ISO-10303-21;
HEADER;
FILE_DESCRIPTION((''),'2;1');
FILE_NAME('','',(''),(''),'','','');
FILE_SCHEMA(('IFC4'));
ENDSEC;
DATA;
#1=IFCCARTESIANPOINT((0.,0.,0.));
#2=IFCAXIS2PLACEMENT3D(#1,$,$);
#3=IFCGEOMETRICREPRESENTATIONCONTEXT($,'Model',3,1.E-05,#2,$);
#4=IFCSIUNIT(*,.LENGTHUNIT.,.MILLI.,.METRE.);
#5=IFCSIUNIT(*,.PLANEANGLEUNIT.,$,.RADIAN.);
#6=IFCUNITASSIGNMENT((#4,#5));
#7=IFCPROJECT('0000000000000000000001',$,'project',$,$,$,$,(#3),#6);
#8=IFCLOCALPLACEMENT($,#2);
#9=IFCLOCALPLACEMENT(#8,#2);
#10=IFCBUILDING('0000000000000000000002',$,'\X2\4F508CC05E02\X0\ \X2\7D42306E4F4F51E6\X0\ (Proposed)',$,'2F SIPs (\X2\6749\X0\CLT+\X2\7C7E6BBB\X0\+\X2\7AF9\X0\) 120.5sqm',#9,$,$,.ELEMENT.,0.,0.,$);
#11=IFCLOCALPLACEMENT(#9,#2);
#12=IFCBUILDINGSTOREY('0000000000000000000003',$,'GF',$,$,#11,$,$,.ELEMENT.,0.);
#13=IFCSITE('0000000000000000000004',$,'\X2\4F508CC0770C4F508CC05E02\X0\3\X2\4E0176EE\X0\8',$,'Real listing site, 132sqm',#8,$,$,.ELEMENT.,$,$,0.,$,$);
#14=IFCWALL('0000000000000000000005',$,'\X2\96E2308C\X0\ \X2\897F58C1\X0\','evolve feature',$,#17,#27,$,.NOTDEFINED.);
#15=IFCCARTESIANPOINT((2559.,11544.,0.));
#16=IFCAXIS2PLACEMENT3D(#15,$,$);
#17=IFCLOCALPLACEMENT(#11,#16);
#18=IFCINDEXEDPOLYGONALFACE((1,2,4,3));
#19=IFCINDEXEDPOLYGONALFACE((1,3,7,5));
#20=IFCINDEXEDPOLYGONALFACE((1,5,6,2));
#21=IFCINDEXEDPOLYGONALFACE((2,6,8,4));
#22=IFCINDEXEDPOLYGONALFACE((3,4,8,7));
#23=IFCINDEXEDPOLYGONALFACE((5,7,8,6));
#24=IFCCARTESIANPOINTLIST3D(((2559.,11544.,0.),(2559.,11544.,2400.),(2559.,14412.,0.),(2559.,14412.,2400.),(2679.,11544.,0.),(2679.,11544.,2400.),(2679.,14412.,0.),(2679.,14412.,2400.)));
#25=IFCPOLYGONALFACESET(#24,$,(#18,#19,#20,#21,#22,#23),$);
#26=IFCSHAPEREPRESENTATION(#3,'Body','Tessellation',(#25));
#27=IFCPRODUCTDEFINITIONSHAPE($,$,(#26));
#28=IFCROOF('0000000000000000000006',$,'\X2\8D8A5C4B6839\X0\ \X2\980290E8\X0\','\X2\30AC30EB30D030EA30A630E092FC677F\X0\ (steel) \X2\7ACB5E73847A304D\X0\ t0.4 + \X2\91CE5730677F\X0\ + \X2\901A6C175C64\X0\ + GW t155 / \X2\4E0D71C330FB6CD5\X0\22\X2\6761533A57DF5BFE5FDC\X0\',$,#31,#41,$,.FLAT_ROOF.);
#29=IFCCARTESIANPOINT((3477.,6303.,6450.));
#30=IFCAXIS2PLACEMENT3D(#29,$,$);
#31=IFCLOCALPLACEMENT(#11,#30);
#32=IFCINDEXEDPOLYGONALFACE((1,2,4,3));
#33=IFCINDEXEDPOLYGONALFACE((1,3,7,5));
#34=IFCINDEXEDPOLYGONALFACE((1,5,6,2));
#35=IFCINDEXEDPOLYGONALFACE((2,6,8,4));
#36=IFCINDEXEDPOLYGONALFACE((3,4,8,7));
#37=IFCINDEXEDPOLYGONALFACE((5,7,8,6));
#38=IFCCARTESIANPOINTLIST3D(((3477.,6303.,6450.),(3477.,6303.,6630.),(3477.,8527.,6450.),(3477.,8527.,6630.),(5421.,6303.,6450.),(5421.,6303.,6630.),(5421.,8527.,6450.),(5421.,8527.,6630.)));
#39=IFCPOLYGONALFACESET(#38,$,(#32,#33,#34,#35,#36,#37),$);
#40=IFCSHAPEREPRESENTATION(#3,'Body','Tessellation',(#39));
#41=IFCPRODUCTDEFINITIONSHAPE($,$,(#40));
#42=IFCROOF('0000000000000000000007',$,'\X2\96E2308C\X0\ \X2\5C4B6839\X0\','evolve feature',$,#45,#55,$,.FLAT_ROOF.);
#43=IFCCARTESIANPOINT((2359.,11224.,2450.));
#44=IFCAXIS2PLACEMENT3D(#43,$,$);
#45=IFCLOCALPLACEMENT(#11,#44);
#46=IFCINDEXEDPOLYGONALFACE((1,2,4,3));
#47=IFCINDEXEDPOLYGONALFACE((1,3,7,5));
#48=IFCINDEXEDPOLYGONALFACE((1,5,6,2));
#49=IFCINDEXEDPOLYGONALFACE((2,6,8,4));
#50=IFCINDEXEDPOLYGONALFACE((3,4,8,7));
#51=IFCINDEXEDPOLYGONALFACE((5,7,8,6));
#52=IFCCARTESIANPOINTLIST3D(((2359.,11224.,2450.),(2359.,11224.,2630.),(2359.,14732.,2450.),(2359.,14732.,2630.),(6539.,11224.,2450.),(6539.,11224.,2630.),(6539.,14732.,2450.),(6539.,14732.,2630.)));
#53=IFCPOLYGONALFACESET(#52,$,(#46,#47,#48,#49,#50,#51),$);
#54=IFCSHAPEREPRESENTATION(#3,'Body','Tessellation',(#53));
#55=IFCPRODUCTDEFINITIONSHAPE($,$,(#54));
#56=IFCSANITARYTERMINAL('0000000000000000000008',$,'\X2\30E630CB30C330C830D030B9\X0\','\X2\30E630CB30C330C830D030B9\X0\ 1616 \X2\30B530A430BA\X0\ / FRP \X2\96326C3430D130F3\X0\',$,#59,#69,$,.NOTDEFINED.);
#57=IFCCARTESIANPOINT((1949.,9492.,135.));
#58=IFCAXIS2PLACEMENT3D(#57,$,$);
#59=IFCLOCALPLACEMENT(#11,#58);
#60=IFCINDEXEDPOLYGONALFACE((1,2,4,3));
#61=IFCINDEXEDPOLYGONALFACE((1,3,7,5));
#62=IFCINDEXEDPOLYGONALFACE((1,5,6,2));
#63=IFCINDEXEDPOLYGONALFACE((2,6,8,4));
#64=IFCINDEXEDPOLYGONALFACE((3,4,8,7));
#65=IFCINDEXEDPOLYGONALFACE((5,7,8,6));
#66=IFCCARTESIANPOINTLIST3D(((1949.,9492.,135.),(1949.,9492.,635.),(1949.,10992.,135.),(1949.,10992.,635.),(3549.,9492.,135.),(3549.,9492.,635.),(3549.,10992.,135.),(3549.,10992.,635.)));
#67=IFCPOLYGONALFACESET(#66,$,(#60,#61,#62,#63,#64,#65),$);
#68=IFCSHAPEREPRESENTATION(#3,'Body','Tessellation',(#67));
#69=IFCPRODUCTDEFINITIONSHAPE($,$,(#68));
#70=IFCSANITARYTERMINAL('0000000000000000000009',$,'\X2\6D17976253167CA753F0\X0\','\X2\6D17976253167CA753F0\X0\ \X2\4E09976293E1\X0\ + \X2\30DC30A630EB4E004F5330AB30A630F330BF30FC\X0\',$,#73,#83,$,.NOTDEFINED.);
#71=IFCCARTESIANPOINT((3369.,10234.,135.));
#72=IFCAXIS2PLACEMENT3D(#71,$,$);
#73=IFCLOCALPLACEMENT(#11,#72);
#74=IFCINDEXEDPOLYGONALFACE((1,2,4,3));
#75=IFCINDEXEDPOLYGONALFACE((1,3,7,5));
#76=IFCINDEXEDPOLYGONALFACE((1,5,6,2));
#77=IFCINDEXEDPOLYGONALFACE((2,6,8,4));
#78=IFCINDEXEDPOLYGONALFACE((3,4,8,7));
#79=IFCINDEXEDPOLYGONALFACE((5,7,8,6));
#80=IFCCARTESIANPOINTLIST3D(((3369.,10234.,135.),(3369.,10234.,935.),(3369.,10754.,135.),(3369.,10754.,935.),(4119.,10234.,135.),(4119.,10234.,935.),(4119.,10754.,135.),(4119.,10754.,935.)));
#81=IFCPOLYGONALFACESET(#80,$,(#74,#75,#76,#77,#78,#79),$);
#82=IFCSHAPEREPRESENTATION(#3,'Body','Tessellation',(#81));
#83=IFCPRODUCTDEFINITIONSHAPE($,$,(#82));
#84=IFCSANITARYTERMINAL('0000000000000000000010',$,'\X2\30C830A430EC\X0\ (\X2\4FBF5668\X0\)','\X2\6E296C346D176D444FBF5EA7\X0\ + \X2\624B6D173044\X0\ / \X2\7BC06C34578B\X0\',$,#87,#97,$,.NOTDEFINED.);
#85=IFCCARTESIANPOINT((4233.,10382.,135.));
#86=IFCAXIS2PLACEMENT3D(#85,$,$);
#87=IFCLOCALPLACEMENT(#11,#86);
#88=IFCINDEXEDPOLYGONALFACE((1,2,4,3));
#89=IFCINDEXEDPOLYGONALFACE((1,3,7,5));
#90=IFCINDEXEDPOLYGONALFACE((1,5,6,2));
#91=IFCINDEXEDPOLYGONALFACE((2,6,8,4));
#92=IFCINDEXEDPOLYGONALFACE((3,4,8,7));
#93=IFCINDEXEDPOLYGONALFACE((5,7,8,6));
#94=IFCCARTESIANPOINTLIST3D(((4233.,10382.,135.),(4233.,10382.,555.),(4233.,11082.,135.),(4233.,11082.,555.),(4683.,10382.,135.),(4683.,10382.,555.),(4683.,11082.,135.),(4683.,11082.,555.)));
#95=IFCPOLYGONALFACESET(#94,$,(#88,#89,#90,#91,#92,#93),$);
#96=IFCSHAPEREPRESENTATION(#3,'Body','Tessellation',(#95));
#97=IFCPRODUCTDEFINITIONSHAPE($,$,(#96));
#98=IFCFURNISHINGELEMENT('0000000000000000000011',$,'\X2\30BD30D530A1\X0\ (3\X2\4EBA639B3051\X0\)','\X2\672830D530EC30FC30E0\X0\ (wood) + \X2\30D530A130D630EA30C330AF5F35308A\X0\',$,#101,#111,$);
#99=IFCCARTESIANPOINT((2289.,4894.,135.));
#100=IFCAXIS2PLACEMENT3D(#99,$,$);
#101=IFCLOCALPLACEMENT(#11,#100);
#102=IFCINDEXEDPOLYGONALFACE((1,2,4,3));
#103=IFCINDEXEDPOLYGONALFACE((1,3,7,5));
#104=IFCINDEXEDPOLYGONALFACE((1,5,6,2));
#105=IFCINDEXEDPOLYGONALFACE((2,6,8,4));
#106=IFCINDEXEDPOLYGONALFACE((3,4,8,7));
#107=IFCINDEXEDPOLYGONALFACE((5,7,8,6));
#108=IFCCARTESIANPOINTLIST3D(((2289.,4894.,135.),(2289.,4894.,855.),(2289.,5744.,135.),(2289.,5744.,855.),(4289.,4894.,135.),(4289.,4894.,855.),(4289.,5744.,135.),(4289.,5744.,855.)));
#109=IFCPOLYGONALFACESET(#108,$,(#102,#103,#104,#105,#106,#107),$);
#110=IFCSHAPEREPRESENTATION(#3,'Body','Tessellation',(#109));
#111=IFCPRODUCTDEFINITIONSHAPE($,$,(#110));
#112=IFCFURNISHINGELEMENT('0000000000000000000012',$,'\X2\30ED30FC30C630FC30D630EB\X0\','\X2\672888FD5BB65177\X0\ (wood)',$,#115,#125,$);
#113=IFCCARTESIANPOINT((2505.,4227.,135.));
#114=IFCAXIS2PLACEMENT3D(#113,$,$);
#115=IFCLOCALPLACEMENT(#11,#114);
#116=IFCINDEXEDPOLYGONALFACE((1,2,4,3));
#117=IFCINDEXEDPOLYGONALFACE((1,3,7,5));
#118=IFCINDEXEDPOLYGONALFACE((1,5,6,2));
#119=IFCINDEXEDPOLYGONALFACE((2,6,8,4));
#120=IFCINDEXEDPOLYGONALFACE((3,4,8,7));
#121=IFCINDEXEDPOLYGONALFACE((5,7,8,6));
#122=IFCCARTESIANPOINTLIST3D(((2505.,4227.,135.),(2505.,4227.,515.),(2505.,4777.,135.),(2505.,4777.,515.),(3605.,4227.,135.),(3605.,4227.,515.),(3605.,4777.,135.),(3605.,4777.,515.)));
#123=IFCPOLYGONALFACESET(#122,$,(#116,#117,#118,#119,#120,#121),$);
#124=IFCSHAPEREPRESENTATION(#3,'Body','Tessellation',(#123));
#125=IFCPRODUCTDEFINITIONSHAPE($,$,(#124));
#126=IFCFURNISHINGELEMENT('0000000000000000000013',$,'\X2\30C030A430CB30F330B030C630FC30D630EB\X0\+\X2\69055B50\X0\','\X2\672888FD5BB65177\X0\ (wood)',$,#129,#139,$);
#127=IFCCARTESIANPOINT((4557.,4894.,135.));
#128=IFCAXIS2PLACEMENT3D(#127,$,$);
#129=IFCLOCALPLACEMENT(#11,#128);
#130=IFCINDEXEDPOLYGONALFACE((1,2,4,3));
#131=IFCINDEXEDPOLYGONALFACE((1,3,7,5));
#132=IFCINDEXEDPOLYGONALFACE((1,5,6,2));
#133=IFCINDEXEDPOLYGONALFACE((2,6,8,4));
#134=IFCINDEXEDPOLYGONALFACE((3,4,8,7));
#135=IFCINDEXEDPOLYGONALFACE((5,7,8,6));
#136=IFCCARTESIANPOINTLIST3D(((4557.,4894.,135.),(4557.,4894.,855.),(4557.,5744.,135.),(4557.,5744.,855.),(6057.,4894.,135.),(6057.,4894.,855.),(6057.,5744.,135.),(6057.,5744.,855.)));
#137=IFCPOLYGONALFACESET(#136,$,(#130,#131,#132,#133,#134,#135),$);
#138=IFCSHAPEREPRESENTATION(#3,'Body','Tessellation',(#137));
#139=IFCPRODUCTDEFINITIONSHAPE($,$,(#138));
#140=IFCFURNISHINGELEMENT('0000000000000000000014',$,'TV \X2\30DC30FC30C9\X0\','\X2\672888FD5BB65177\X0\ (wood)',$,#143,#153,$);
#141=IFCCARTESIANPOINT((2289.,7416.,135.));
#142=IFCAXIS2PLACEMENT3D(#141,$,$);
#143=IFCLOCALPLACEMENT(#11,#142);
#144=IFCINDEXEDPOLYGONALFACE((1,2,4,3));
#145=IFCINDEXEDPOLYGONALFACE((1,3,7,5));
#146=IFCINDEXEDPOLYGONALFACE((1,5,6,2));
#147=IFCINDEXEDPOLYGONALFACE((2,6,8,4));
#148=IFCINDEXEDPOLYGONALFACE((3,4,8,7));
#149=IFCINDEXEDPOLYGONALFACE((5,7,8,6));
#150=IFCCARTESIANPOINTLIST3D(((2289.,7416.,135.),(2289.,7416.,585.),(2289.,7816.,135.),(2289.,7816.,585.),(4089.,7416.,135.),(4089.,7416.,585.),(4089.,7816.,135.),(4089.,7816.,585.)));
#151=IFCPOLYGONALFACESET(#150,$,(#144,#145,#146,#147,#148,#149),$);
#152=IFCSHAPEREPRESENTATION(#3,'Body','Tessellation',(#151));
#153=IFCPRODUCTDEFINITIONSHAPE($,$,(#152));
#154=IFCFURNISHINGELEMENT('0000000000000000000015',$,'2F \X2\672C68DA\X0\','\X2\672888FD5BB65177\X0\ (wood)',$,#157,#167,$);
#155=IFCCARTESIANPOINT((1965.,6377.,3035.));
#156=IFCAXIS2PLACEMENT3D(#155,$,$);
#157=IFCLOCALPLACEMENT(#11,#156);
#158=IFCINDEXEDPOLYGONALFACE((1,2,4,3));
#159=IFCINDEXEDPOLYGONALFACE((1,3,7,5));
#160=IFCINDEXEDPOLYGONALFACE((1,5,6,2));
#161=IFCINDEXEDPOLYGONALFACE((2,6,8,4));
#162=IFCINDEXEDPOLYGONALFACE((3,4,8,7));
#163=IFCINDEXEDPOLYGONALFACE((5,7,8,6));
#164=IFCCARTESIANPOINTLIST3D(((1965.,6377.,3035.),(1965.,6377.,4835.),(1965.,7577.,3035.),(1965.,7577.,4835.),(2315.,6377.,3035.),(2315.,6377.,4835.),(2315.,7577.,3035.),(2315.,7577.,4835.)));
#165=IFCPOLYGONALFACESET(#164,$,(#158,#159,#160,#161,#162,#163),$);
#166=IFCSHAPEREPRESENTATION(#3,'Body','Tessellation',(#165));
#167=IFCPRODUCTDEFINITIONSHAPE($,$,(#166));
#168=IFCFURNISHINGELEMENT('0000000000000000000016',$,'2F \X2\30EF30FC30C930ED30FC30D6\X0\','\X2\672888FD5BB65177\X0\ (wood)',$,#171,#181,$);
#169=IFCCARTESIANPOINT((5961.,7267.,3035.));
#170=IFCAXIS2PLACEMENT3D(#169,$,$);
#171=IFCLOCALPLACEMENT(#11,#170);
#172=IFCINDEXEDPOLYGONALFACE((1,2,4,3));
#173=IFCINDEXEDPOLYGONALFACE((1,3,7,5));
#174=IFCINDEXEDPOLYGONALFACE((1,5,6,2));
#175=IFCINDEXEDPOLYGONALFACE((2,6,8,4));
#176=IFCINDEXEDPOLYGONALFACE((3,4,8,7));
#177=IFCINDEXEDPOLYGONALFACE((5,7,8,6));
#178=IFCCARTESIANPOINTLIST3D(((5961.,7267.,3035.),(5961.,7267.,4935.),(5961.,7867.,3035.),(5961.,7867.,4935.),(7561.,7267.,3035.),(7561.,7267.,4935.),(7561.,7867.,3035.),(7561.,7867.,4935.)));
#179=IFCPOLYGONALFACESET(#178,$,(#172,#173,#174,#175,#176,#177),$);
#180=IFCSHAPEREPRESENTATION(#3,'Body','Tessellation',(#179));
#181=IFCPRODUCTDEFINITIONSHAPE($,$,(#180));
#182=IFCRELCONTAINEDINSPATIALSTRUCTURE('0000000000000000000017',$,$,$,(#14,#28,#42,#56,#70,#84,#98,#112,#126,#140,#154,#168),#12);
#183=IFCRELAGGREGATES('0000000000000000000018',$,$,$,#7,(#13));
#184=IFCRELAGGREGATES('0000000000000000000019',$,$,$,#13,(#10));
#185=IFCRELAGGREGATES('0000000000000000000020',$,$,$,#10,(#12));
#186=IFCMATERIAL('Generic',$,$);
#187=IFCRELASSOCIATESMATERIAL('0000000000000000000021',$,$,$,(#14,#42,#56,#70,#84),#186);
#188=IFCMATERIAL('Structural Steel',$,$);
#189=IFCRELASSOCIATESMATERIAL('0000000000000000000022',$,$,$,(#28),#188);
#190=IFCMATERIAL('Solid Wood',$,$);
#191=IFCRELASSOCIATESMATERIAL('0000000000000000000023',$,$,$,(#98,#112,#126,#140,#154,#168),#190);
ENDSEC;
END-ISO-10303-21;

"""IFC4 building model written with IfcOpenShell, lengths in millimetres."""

from ifc_helpers import new_model, si_unit, frame, frame_2d, origin, place, context, project, spatial, rectangle, extrude, material, element, save


model = new_model("IFC4")

# Units and contexts
model_context = context("Model", 3, precision=1e-05, world=origin())
ifc_project = project(units=[si_unit("LENGTHUNIT", "METRE", prefix="MILLI"), si_unit("PLANEANGLEUNIT", "RADIAN")], contexts=[model_context])

# Site, building, storey
site_placement = place(None, origin())
site = spatial("IfcSite", under=ifc_project, at=site_placement, Name="佐賀県佐賀市3丁目8", ObjectType="Real listing site, 132sqm", CompositionType="ELEMENT", RefElevation=0.0)
building_placement = place(site_placement, origin())
building = spatial("IfcBuilding", under=site, at=building_placement, Name="佐賀市 終の住処 (Proposed)", ObjectType="2F SIPs (杉CLT+籾殻+竹) 120.5sqm", CompositionType="ELEMENT", ElevationOfRefHeight=0.0, ElevationOfTerrain=0.0)
storey_placement = place(building_placement, origin())
storey = spatial("IfcBuildingStorey", under=building, at=storey_placement, Name="GF", CompositionType="ELEMENT", Elevation=0.0)

# Shared definitions
ifc_material_1 = material(Name="Generic")

# Shared definitions
ifc_material_2 = material(Name="Solid Wood")

# Wall
wall_1_placement = place(storey_placement, frame((2559.0, 11544.0, 0.0)))
element("IfcWall", 1, at=wall_1_placement, inside=storey, material=ifc_material_1, Name="離れ 西壁", Description="evolve feature", PredefinedType="NOTDEFINED", context=model_context, shape_type="SweptSolid", body=[
    extrude(rectangle(XDim=120.0, YDim=2868.0, at=frame_2d((60.0, 1434.0))), frame((2559.0, 11544.0, 0.0)), (0.0, 0.0, 1.0), 2400.0),
])

# Roofs
ifc_material_3 = material(Name="Structural Steel")
roof_1_placement = place(storey_placement, frame((3477.0, 6303.0, 6450.0)))
element("IfcRoof", 2, at=roof_1_placement, inside=storey, material=ifc_material_3, Name="越屋根 頂部", Description="ガルバリウム鋼板 (steel) 立平葺き t0.4 + 野地板 + 通気層 + GW t155 / 不燃・法22条区域対応", PredefinedType="FLAT_ROOF", context=model_context, shape_type="SweptSolid", body=[
    extrude(rectangle(XDim=1944.0, YDim=2224.0, at=frame_2d((972.0, 1112.0))), frame((3477.0, 6303.0, 6450.0)), (0.0, 0.0, 1.0), 180.0),
])
roof_2_placement = place(storey_placement, frame((2359.0, 11224.0, 2450.0)))
element("IfcRoof", 3, at=roof_2_placement, inside=storey, material=ifc_material_1, Name="離れ 屋根", Description="evolve feature", PredefinedType="FLAT_ROOF", context=model_context, shape_type="SweptSolid", body=[
    extrude(rectangle(XDim=4180.0, YDim=3508.0, at=frame_2d((2090.0, 1754.0))), frame((2359.0, 11224.0, 2450.0)), (0.0, 0.0, 1.0), 180.0),
])

# Sanitary terminals
sanitary_terminal_1_placement = place(storey_placement, frame((1949.0, 9492.0, 135.0)))
element("IfcSanitaryTerminal", 4, at=sanitary_terminal_1_placement, inside=storey, material=ifc_material_1, Name="ユニットバス", Description="ユニットバス 1616 サイズ / FRP 防水パン", PredefinedType="NOTDEFINED", context=model_context, shape_type="SweptSolid", body=[
    extrude(rectangle(XDim=1600.0, YDim=1500.0, at=frame_2d((800.0, 750.0))), frame((1949.0, 9492.0, 135.0)), (0.0, 0.0, 1.0), 500.0),
])
sanitary_terminal_2_placement = place(storey_placement, frame((3369.0, 10234.0, 135.0)))
element("IfcSanitaryTerminal", 5, at=sanitary_terminal_2_placement, inside=storey, material=ifc_material_1, Name="洗面化粧台", Description="洗面化粧台 三面鏡 + ボウル一体カウンター", PredefinedType="NOTDEFINED", context=model_context, shape_type="SweptSolid", body=[
    extrude(rectangle(XDim=750.0, YDim=520.0, at=frame_2d((375.0, 260.0))), frame((3369.0, 10234.0, 135.0)), (0.0, 0.0, 1.0), 800.0),
])
sanitary_terminal_3_placement = place(storey_placement, frame((4233.0, 10382.0, 135.0)))
element("IfcSanitaryTerminal", 6, at=sanitary_terminal_3_placement, inside=storey, material=ifc_material_1, Name="トイレ (便器)", Description="温水洗浄便座 + 手洗い / 節水型", PredefinedType="NOTDEFINED", context=model_context, shape_type="SweptSolid", body=[
    extrude(rectangle(XDim=450.0, YDim=700.0, at=frame_2d((225.0, 350.0))), frame((4233.0, 10382.0, 135.0)), (0.0, 0.0, 1.0), 420.0),
])

# Furnishing elements
furnishing_1_placement = place(storey_placement, frame((2289.0, 4894.0, 135.0)))
element("IfcFurnishingElement", 7, at=furnishing_1_placement, inside=storey, material=ifc_material_2, Name="ソファ (3人掛け)", Description="木フレーム (wood) + ファブリック張り", context=model_context, shape_type="SweptSolid", body=[
    extrude(rectangle(XDim=2000.0, YDim=850.0, at=frame_2d((1000.0, 425.0))), frame((2289.0, 4894.0, 135.0)), (0.0, 0.0, 1.0), 720.0),
])
furnishing_2_placement = place(storey_placement, frame((2505.0, 4227.0, 135.0)))
element("IfcFurnishingElement", 8, at=furnishing_2_placement, inside=storey, material=ifc_material_2, Name="ローテーブル", Description="木製家具 (wood)", context=model_context, shape_type="SweptSolid", body=[
    extrude(rectangle(XDim=1100.0, YDim=550.0, at=frame_2d((550.0, 275.0))), frame((2505.0, 4227.0, 135.0)), (0.0, 0.0, 1.0), 380.0),
])
furnishing_3_placement = place(storey_placement, frame((4557.0, 4894.0, 135.0)))
element("IfcFurnishingElement", 9, at=furnishing_3_placement, inside=storey, material=ifc_material_2, Name="ダイニングテーブル+椅子", Description="木製家具 (wood)", context=model_context, shape_type="SweptSolid", body=[
    extrude(rectangle(XDim=1500.0, YDim=850.0, at=frame_2d((750.0, 425.0))), frame((4557.0, 4894.0, 135.0)), (0.0, 0.0, 1.0), 720.0),
])
furnishing_4_placement = place(storey_placement, frame((2289.0, 7416.0, 135.0)))
element("IfcFurnishingElement", 10, at=furnishing_4_placement, inside=storey, material=ifc_material_2, Name="TV ボード", Description="木製家具 (wood)", context=model_context, shape_type="SweptSolid", body=[
    extrude(rectangle(XDim=1800.0, YDim=400.0, at=frame_2d((900.0, 200.0))), frame((2289.0, 7416.0, 135.0)), (0.0, 0.0, 1.0), 450.0),
])
furnishing_5_placement = place(storey_placement, frame((1965.0, 6377.0, 3035.0)))
element("IfcFurnishingElement", 11, at=furnishing_5_placement, inside=storey, material=ifc_material_2, Name="2F 本棚", Description="木製家具 (wood)", context=model_context, shape_type="SweptSolid", body=[
    extrude(rectangle(XDim=350.0, YDim=1200.0, at=frame_2d((175.0, 600.0))), frame((1965.0, 6377.0, 3035.0)), (0.0, 0.0, 1.0), 1800.0),
])
furnishing_6_placement = place(storey_placement, frame((5961.0, 7267.0, 3035.0)))
element("IfcFurnishingElement", 12, at=furnishing_6_placement, inside=storey, material=ifc_material_2, Name="2F ワードローブ", Description="木製家具 (wood)", context=model_context, shape_type="SweptSolid", body=[
    extrude(rectangle(XDim=1600.0, YDim=600.0, at=frame_2d((800.0, 300.0))), frame((5961.0, 7267.0, 3035.0)), (0.0, 0.0, 1.0), 1900.0),
])

save(model, "model.ifc")
